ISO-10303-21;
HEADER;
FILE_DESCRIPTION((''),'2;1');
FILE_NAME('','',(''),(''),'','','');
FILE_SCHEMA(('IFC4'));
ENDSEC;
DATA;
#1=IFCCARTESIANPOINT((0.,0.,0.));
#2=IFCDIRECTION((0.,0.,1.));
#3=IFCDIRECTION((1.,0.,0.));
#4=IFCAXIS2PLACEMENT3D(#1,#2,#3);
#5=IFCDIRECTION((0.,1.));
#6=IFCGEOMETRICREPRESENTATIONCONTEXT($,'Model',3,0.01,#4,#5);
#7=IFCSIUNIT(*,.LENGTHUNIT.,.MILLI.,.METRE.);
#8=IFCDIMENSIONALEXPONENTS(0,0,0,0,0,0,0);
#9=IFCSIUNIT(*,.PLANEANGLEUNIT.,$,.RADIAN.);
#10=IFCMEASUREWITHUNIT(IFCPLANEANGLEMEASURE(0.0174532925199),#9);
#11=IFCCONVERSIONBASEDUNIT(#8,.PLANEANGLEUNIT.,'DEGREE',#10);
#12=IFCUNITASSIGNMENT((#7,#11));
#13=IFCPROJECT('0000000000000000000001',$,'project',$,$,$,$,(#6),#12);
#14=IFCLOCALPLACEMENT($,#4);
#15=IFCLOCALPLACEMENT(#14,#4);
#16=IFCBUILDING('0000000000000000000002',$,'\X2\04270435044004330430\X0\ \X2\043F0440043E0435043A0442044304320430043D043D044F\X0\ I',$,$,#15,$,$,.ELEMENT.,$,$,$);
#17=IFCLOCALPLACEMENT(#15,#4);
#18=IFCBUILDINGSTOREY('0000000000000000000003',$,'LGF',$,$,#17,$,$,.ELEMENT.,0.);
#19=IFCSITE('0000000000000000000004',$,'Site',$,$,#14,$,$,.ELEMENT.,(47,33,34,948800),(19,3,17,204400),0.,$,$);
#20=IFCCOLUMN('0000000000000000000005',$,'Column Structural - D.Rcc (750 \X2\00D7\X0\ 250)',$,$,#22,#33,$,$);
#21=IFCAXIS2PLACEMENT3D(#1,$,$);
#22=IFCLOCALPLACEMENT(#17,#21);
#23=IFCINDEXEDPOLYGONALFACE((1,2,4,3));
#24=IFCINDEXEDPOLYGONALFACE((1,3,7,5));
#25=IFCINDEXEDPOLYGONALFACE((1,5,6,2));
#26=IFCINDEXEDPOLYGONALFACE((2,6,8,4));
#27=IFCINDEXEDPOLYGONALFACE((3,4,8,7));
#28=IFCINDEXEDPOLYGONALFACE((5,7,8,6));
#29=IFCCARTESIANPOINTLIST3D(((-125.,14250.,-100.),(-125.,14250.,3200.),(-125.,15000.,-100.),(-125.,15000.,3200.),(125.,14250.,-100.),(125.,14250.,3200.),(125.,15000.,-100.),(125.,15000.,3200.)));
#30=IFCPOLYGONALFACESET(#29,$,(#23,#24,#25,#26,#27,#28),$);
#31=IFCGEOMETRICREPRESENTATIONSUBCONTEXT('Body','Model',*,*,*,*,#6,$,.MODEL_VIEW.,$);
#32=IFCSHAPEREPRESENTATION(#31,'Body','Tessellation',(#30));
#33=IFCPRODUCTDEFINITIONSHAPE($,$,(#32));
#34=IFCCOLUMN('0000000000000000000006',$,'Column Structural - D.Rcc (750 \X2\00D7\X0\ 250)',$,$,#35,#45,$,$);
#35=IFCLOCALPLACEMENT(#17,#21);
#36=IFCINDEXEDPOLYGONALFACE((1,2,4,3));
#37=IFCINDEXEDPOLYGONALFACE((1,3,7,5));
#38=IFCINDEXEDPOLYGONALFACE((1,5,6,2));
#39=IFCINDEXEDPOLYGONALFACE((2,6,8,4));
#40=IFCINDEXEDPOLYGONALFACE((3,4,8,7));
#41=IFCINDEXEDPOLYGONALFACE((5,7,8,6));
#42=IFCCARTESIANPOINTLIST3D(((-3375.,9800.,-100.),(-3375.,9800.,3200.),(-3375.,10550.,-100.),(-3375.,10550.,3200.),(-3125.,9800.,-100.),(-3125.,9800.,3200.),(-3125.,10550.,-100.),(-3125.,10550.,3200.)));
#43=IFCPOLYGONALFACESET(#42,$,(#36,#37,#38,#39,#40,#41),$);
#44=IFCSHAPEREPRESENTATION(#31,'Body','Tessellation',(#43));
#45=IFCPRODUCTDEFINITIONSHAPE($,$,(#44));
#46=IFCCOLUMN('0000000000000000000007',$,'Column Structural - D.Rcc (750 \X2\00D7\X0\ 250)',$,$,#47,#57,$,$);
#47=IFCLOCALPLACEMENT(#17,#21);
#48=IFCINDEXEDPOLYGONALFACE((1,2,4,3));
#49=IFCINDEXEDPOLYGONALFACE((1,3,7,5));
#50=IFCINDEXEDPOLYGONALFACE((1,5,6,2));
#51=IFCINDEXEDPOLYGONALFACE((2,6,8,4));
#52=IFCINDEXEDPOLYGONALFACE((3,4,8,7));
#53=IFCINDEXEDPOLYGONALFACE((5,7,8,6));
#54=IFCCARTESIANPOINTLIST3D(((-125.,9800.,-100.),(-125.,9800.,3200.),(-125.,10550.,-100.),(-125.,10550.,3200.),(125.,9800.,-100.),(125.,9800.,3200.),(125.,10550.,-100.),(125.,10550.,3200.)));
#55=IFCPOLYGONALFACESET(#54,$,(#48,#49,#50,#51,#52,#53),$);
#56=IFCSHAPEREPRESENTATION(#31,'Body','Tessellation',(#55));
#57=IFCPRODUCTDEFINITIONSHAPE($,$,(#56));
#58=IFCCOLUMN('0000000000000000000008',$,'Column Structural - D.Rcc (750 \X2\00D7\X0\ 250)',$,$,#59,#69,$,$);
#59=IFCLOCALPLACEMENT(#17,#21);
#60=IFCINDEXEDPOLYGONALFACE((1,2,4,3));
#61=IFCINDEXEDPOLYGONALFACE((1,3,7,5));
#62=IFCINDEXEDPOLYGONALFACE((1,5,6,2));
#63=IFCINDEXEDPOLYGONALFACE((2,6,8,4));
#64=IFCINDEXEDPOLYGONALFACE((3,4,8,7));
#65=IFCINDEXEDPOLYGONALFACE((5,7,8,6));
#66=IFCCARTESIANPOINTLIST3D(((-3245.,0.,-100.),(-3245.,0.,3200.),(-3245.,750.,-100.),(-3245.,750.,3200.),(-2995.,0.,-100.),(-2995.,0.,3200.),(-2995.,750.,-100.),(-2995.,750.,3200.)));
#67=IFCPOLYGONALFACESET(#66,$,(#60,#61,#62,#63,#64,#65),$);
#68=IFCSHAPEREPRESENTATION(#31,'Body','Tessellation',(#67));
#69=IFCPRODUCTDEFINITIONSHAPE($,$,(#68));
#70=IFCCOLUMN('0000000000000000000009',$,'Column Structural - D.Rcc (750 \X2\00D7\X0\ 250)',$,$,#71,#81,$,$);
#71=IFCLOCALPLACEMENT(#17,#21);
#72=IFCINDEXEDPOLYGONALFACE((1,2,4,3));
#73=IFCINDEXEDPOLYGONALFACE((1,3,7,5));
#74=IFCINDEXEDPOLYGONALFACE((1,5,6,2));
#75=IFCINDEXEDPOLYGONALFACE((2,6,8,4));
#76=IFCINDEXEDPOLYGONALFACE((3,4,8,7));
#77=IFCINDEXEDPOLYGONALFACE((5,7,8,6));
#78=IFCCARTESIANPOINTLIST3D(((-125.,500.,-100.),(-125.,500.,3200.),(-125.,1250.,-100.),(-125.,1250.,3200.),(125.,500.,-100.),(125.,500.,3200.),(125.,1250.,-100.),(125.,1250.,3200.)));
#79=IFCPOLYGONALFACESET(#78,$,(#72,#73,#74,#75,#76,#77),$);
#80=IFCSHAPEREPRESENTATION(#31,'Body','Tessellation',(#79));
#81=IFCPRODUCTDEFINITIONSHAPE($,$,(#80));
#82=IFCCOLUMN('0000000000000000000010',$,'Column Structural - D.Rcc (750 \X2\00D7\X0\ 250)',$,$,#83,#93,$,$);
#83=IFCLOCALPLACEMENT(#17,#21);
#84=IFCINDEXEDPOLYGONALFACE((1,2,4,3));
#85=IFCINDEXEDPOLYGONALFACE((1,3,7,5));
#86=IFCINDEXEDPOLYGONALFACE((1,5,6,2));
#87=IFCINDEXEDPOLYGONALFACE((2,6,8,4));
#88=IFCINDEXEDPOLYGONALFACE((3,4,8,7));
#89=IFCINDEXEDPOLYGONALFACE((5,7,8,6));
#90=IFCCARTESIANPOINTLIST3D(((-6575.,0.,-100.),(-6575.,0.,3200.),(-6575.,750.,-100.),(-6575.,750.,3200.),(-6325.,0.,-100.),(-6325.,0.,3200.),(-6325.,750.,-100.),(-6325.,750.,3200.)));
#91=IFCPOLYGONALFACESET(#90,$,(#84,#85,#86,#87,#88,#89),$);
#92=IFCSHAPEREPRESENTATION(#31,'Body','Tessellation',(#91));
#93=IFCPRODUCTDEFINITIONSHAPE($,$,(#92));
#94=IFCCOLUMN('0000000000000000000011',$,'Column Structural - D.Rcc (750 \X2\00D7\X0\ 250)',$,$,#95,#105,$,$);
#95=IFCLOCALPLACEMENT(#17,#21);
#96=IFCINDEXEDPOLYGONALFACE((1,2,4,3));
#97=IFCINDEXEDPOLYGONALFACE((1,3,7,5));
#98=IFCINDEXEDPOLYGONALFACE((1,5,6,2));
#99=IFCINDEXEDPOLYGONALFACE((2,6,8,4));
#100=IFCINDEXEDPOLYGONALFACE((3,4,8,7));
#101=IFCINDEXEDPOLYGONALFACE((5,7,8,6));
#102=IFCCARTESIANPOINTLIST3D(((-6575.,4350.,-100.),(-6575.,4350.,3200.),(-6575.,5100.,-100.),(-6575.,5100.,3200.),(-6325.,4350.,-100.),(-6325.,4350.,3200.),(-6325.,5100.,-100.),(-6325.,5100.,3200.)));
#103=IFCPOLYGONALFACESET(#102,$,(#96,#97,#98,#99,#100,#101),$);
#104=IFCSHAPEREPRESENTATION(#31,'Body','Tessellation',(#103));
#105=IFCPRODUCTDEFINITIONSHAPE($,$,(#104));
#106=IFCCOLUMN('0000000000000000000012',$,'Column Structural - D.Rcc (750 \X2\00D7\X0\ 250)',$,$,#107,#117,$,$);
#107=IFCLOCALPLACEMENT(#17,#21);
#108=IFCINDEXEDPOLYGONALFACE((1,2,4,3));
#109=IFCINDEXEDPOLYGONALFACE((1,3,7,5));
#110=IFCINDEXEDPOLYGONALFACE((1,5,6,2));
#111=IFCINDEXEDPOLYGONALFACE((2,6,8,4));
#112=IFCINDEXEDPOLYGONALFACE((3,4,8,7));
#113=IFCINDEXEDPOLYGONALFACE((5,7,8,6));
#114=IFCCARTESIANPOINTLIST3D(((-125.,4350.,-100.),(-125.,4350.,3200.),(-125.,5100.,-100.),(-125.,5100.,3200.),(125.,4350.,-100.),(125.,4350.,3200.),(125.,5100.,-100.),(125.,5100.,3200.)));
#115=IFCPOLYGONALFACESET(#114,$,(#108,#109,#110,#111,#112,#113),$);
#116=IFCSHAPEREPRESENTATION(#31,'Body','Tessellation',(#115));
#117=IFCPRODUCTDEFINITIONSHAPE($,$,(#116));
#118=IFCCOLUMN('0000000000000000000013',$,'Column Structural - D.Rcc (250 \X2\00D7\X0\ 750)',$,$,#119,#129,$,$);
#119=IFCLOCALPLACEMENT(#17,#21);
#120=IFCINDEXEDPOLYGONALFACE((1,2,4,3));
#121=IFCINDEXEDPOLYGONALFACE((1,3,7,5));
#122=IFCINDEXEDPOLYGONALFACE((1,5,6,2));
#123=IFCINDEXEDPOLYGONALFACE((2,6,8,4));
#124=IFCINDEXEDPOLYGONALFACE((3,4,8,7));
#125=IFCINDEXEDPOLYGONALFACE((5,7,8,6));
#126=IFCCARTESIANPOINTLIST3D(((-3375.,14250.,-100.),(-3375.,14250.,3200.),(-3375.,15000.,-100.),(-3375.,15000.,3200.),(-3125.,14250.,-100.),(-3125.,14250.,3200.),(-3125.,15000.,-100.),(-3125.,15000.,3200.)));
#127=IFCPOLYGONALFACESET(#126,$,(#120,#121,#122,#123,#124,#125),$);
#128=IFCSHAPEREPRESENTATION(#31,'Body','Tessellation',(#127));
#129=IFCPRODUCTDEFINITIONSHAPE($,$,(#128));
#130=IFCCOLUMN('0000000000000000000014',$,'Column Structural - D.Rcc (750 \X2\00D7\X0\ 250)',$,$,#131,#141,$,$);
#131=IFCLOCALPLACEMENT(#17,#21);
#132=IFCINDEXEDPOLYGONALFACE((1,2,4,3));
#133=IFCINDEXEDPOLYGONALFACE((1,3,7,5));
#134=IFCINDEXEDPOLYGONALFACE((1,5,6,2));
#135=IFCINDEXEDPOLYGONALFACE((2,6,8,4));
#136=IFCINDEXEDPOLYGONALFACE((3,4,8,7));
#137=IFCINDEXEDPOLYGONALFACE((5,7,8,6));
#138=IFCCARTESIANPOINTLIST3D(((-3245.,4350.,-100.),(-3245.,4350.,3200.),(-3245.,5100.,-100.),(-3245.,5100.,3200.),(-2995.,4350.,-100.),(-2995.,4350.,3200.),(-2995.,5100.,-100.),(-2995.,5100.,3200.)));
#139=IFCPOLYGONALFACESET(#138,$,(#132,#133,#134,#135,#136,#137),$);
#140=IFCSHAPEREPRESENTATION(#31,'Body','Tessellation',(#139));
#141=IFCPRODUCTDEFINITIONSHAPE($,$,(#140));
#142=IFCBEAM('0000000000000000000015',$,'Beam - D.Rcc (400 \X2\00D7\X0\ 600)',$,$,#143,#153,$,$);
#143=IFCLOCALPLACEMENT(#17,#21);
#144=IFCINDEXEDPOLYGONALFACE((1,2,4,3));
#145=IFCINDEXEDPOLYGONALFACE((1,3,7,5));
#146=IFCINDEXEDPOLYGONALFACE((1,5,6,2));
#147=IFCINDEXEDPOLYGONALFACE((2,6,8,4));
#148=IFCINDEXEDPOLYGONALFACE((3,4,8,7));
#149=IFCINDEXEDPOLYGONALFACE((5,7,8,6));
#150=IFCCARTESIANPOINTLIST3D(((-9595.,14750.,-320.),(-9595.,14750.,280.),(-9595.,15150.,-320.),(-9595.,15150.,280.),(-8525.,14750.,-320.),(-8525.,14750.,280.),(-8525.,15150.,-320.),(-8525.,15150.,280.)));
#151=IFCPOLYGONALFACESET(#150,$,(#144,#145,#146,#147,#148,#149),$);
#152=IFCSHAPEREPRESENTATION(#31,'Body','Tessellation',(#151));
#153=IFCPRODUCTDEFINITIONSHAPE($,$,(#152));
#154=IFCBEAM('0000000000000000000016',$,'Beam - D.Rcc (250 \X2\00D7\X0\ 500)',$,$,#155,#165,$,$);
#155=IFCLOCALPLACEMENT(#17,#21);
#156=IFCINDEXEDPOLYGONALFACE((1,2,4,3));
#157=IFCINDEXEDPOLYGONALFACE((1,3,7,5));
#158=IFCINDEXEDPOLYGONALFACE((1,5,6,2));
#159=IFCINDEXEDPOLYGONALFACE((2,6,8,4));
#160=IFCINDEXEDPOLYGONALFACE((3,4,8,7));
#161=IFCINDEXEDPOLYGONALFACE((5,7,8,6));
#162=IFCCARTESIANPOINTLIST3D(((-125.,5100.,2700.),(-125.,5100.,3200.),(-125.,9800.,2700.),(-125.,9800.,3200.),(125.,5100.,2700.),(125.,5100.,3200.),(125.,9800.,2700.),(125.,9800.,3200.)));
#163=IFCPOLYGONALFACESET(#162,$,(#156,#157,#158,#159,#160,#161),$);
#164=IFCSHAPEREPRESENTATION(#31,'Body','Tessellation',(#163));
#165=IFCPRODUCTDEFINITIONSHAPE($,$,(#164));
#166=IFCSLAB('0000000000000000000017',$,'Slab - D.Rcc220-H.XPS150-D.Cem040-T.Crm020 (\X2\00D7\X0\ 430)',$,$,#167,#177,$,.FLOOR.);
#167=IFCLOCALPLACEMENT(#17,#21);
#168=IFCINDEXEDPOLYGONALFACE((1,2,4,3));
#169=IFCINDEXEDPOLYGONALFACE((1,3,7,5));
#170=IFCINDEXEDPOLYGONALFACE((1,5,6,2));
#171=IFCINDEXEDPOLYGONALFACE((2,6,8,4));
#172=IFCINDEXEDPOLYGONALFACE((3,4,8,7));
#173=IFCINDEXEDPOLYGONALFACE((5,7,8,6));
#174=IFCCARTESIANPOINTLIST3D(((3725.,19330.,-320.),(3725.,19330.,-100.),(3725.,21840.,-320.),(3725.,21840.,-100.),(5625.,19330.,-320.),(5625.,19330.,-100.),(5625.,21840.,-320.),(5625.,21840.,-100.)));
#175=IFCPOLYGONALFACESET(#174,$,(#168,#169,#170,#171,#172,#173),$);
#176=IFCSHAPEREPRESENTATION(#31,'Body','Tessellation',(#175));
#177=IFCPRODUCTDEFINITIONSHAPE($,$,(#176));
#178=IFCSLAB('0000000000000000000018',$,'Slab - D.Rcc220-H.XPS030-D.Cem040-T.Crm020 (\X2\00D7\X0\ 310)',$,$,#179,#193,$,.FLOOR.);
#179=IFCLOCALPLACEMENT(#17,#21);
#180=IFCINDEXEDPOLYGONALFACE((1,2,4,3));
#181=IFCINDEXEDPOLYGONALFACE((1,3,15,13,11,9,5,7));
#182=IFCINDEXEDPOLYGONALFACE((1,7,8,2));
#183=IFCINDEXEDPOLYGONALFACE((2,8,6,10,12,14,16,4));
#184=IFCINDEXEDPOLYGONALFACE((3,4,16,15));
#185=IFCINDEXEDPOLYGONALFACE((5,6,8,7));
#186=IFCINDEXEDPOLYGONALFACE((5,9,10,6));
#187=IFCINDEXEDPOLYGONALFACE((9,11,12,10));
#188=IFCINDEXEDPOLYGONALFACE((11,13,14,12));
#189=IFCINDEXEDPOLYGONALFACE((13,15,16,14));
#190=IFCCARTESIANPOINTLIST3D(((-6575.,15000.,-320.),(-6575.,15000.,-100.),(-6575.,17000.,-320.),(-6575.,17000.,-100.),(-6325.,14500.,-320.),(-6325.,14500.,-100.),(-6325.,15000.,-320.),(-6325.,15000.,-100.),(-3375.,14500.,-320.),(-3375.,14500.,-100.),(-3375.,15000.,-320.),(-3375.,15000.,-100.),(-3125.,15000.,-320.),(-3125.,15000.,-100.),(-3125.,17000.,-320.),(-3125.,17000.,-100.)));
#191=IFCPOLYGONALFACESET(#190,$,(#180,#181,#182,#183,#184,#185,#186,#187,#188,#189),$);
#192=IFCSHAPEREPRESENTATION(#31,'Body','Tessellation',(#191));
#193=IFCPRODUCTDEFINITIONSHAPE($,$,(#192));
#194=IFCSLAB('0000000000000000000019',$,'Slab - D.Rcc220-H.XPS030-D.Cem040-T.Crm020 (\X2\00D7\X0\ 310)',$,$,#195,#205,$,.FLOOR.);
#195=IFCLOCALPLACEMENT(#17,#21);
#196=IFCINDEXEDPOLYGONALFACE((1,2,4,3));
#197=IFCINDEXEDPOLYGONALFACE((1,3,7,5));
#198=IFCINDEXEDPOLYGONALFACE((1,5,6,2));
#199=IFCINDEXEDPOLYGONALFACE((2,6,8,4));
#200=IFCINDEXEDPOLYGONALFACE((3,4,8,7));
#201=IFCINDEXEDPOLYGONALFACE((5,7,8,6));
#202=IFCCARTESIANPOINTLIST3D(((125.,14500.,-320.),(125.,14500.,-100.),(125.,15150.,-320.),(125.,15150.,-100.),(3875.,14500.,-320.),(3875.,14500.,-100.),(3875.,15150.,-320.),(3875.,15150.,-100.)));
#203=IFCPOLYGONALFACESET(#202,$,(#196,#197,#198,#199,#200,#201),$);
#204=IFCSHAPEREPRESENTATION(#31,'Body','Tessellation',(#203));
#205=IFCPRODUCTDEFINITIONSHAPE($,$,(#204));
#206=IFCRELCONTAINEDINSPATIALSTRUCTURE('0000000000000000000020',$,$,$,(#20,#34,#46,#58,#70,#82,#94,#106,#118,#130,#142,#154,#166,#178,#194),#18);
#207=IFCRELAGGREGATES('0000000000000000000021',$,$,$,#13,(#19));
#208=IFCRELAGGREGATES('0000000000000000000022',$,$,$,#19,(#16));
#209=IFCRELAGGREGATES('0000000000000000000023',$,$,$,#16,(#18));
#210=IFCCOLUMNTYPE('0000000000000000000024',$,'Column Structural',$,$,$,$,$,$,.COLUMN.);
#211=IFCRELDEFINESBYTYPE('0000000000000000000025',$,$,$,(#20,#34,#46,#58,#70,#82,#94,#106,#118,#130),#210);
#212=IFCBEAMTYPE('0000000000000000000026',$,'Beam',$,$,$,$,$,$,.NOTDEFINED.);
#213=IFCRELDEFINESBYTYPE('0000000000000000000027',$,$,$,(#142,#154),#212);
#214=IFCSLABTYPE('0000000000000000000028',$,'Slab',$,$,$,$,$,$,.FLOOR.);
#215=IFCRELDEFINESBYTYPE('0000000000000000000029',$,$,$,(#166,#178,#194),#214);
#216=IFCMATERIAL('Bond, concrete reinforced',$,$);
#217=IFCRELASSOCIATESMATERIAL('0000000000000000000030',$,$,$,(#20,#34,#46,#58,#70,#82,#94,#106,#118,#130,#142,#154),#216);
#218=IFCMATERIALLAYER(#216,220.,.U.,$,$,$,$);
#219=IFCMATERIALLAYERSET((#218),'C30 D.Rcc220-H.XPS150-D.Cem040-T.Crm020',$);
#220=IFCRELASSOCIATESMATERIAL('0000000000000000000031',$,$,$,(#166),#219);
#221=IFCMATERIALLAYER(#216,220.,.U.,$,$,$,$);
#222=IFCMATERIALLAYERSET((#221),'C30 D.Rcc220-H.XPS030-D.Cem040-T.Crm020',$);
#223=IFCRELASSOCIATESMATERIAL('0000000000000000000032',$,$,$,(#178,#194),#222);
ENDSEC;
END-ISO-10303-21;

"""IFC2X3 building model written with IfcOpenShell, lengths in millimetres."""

from ifc_helpers import new_model, entity, si_unit, converted_unit, direction, frame, frame_2d, origin_with_axes, origin_2d_with_axis, place, context, subcontext, project, spatial, polyline, rectangle, outline, extrude, material, layer, layer_set, layer_usage, type_object, element, save


model = new_model("IFC2X3")

# Units and contexts
model_context = context("Model", 3, precision=0.01, world=origin_with_axes(), true_north=direction((0.0, 1.0)))
body_context = subcontext(model_context, "Body", "Model", "MODEL_VIEW")
ifc_project = project(units=[si_unit("LENGTHUNIT", "METRE", prefix="MILLI"), converted_unit("PLANEANGLEUNIT", "DEGREE", entity("IfcPlaneAngleMeasure", 0.0174532925199), si_unit("PLANEANGLEUNIT", "RADIAN"), dimensions=[0, 0, 0, 0, 0, 0, 0])], contexts=[model_context])

# Site, building, storey
site_placement = place(None, origin_with_axes())
site = spatial("IfcSite", under=ifc_project, at=site_placement, Name="Site", CompositionType="ELEMENT", RefLatitude=(47, 33, 34, 948800), RefLongitude=(19, 3, 17, 204400), RefElevation=0.0)
building_placement = place(site_placement, origin_with_axes())
building = spatial("IfcBuilding", under=site, at=building_placement, Name="Черга проектування I", CompositionType="ELEMENT")
storey_placement = place(building_placement, origin_with_axes())
storey = spatial("IfcBuildingStorey", under=building, at=storey_placement, Name="LGF", CompositionType="ELEMENT", Elevation=0.0)

# Columns
ifc_material = material(Name="Bond, concrete reinforced")
column_type = type_object("IfcColumnType", Name="Column Structural", PredefinedType="COLUMN")
for number, where, z_axis, x_axis, name in (
    (1, (0.0, 14625.0, -100.0), (0.0, 0.0, 1.0), (1.0, 0.0, 0.0), "Column Structural - D.Rcc (750 × 250)"),
    (2, (-3250.0, 10175.0, -100.0), (0.0, 0.0, 1.0), (1.0, 0.0, 0.0), "Column Structural - D.Rcc (750 × 250)"),
    (3, (0.0, 10175.0, -100.0), (0.0, 0.0, 1.0), (1.0, 0.0, 0.0), "Column Structural - D.Rcc (750 × 250)"),
    (4, (-3120.0, 375.0, -100.0), (0.0, 0.0, 1.0), (1.0, 0.0, 0.0), "Column Structural - D.Rcc (750 × 250)"),
    (5, (0.0, 875.0, -100.0), (0.0, 0.0, 1.0), (1.0, 0.0, 0.0), "Column Structural - D.Rcc (750 × 250)"),
    (6, (-6450.0, 375.0, -100.0), (0.0, 0.0, 1.0), (1.0, 0.0, 0.0), "Column Structural - D.Rcc (750 × 250)"),
    (7, (-6450.0, 4725.0, -100.0), (0.0, 0.0, 1.0), (1.0, 0.0, 0.0), "Column Structural - D.Rcc (750 × 250)"),
    (8, (0.0, 4725.0, -100.0), (0.0, 0.0, 1.0), (1.0, 0.0, 0.0), "Column Structural - D.Rcc (750 × 250)"),
):
    element("IfcColumn", number, at=place(storey_placement, frame(where, z_axis=z_axis, x_axis=x_axis)), inside=storey, type_object=column_type, material=ifc_material, Name=name, context=body_context, shape_type="SweptSolid", body=[
        extrude(rectangle(XDim=250.0, YDim=750.0, at=origin_2d_with_axis()), origin_with_axes(), (0.0, 0.0, 1.0), 3300.0),
    ])
column_1_placement = place(storey_placement, frame((-3250.0, 14625.0, -100.0), z_axis=(0.0, 0.0, 1.0), x_axis=(0.0, -1.0, 0.0)))
element("IfcColumn", 9, at=column_1_placement, inside=storey, type_object=column_type, material=ifc_material, Name="Column Structural - D.Rcc (250 × 750)", context=body_context, shape_type="SweptSolid", body=[
    extrude(rectangle(XDim=750.0, YDim=250.0, at=origin_2d_with_axis()), origin_with_axes(), (0.0, 0.0, 1.0), 3300.0),
])
column_2_placement = place(storey_placement, frame((-3120.0, 4725.0, -100.0), z_axis=(0.0, 0.0, 1.0), x_axis=(1.0, 0.0, 0.0)))
element("IfcColumn", 10, at=column_2_placement, inside=storey, type_object=column_type, material=ifc_material, Name="Column Structural - D.Rcc (750 × 250)", context=body_context, shape_type="SweptSolid", body=[
    extrude(rectangle(XDim=250.0, YDim=750.0, at=origin_2d_with_axis()), origin_with_axes(), (0.0, 0.0, 1.0), 3300.0),
])

# Beams
beam_type = type_object("IfcBeamType", Name="Beam", PredefinedType="NOTDEFINED")
beam_1_placement = place(storey_placement, frame((-9595.0, 14750.0, -320.0), z_axis=(0.0, 0.0, 1.0), x_axis=(0.0, -1.0, 0.0)))
element("IfcBeam", 11, at=beam_1_placement, inside=storey, type_object=beam_type, material=ifc_material, Name="Beam - D.Rcc (400 × 600)", context=body_context, shape_type="SweptSolid", body=[
    extrude(rectangle(XDim=600.0, YDim=400.0, at=frame_2d((300.0, -200.0), x_axis=(1.0, 0.0))), frame((0.0, 0.0, 0.0), z_axis=(0.0, 1.0, 0.0), x_axis=(0.0, 0.0, 1.0)), (0.0, 0.0, 1.0), 1070.0),
])
beam_2_placement = place(storey_placement, frame((0.0, 5100.0, 2700.0), z_axis=(0.0, 0.0, 1.0), x_axis=(1.0, 0.0, 0.0)))
element("IfcBeam", 12, at=beam_2_placement, inside=storey, type_object=beam_type, material=ifc_material, Name="Beam - D.Rcc (250 × 500)", context=body_context, shape_type="SweptSolid", body=[
    extrude(rectangle(XDim=500.0, YDim=250.0, at=frame_2d((250.0, 0.0), x_axis=(1.0, 0.0))), frame((0.0, 0.0, 0.0), z_axis=(0.0, 1.0, 0.0), x_axis=(0.0, 0.0, 1.0)), (0.0, 0.0, 1.0), 4700.0),
])

# Slabs
ifc_layer_1 = layer(ifc_material, 220.0, ventilated="UNKNOWN")
ifc_layer_set_1 = layer_set([ifc_layer_1], Name="C30 D.Rcc220-H.XPS150-D.Cem040-T.Crm020")
ifc_layer_usage_1 = layer_usage(ifc_layer_set_1, "AXIS3", "NEGATIVE", 220.0)
slab_type = type_object("IfcSlabType", Name="Slab", PredefinedType="FLOOR")
slab_1_placement = place(storey_placement, frame((3725.0, 19330.0, -100.0), z_axis=(0.0, 0.0, 1.0), x_axis=(1.0, 0.0, 0.0)))
element("IfcSlab", 13, at=slab_1_placement, inside=storey, type_object=slab_type, material=ifc_layer_usage_1, Name="Slab - D.Rcc220-H.XPS150-D.Cem040-T.Crm020 (× 430)", PredefinedType="FLOOR", context=body_context, shape_type="SweptSolid", body=[
    extrude(outline(polyline([(0.0, 0.0), (1900.0, 0.0), (1900.0, 2510.0), (0.0, 2510.0), (0.0, 0.0)])), frame((0.0, 0.0, -220.0), z_axis=(0.0, 0.0, 1.0), x_axis=(1.0, 0.0, 0.0)), (0.0, 0.0, 1.0), 220.0),
])
ifc_layer_2 = layer(ifc_material, 220.0, ventilated="UNKNOWN")
ifc_layer_set_2 = layer_set([ifc_layer_2], Name="C30 D.Rcc220-H.XPS030-D.Cem040-T.Crm020")
ifc_layer_usage_2 = layer_usage(ifc_layer_set_2, "AXIS3", "NEGATIVE", 220.0)
slab_2_placement = place(storey_placement, frame((-6575.0, 17000.0, -100.0), z_axis=(0.0, 0.0, 1.0), x_axis=(1.0, 0.0, 0.0)))
element("IfcSlab", 14, at=slab_2_placement, inside=storey, type_object=slab_type, material=ifc_layer_usage_2, Name="Slab - D.Rcc220-H.XPS030-D.Cem040-T.Crm020 (× 310)", PredefinedType="FLOOR", context=body_context, shape_type="SweptSolid", body=[
    extrude(outline(polyline([(0.0, 0.0), (0.0, -2000.0), (250.0, -2000.0), (250.0, -2500.0), (3200.0, -2500.0), (3200.0, -2000.0), (3450.0, -2000.0), (3450.0, 0.0), (0.0, 0.0)])), frame((0.0, 0.0, -220.0), z_axis=(0.0, 0.0, 1.0), x_axis=(1.0, 0.0, 0.0)), (0.0, 0.0, 1.0), 220.0),
])
ifc_layer_usage_3 = layer_usage(ifc_layer_set_2, "AXIS3", "NEGATIVE", 220.0)
slab_3_placement = place(storey_placement, frame((125.0, 14500.0, -100.0), z_axis=(0.0, 0.0, 1.0), x_axis=(1.0, 0.0, 0.0)))
element("IfcSlab", 15, at=slab_3_placement, inside=storey, type_object=slab_type, material=ifc_layer_usage_3, Name="Slab - D.Rcc220-H.XPS030-D.Cem040-T.Crm020 (× 310)", PredefinedType="FLOOR", context=body_context, shape_type="SweptSolid", body=[
    extrude(outline(polyline([(0.0, 0.0), (3750.0, 0.0), (3750.0, 650.0), (0.0, 650.0), (0.0, 0.0)])), frame((0.0, 0.0, -220.0), z_axis=(0.0, 0.0, 1.0), x_axis=(1.0, 0.0, 0.0)), (0.0, 0.0, 1.0), 220.0),
])

save(model, "model.ifc")
